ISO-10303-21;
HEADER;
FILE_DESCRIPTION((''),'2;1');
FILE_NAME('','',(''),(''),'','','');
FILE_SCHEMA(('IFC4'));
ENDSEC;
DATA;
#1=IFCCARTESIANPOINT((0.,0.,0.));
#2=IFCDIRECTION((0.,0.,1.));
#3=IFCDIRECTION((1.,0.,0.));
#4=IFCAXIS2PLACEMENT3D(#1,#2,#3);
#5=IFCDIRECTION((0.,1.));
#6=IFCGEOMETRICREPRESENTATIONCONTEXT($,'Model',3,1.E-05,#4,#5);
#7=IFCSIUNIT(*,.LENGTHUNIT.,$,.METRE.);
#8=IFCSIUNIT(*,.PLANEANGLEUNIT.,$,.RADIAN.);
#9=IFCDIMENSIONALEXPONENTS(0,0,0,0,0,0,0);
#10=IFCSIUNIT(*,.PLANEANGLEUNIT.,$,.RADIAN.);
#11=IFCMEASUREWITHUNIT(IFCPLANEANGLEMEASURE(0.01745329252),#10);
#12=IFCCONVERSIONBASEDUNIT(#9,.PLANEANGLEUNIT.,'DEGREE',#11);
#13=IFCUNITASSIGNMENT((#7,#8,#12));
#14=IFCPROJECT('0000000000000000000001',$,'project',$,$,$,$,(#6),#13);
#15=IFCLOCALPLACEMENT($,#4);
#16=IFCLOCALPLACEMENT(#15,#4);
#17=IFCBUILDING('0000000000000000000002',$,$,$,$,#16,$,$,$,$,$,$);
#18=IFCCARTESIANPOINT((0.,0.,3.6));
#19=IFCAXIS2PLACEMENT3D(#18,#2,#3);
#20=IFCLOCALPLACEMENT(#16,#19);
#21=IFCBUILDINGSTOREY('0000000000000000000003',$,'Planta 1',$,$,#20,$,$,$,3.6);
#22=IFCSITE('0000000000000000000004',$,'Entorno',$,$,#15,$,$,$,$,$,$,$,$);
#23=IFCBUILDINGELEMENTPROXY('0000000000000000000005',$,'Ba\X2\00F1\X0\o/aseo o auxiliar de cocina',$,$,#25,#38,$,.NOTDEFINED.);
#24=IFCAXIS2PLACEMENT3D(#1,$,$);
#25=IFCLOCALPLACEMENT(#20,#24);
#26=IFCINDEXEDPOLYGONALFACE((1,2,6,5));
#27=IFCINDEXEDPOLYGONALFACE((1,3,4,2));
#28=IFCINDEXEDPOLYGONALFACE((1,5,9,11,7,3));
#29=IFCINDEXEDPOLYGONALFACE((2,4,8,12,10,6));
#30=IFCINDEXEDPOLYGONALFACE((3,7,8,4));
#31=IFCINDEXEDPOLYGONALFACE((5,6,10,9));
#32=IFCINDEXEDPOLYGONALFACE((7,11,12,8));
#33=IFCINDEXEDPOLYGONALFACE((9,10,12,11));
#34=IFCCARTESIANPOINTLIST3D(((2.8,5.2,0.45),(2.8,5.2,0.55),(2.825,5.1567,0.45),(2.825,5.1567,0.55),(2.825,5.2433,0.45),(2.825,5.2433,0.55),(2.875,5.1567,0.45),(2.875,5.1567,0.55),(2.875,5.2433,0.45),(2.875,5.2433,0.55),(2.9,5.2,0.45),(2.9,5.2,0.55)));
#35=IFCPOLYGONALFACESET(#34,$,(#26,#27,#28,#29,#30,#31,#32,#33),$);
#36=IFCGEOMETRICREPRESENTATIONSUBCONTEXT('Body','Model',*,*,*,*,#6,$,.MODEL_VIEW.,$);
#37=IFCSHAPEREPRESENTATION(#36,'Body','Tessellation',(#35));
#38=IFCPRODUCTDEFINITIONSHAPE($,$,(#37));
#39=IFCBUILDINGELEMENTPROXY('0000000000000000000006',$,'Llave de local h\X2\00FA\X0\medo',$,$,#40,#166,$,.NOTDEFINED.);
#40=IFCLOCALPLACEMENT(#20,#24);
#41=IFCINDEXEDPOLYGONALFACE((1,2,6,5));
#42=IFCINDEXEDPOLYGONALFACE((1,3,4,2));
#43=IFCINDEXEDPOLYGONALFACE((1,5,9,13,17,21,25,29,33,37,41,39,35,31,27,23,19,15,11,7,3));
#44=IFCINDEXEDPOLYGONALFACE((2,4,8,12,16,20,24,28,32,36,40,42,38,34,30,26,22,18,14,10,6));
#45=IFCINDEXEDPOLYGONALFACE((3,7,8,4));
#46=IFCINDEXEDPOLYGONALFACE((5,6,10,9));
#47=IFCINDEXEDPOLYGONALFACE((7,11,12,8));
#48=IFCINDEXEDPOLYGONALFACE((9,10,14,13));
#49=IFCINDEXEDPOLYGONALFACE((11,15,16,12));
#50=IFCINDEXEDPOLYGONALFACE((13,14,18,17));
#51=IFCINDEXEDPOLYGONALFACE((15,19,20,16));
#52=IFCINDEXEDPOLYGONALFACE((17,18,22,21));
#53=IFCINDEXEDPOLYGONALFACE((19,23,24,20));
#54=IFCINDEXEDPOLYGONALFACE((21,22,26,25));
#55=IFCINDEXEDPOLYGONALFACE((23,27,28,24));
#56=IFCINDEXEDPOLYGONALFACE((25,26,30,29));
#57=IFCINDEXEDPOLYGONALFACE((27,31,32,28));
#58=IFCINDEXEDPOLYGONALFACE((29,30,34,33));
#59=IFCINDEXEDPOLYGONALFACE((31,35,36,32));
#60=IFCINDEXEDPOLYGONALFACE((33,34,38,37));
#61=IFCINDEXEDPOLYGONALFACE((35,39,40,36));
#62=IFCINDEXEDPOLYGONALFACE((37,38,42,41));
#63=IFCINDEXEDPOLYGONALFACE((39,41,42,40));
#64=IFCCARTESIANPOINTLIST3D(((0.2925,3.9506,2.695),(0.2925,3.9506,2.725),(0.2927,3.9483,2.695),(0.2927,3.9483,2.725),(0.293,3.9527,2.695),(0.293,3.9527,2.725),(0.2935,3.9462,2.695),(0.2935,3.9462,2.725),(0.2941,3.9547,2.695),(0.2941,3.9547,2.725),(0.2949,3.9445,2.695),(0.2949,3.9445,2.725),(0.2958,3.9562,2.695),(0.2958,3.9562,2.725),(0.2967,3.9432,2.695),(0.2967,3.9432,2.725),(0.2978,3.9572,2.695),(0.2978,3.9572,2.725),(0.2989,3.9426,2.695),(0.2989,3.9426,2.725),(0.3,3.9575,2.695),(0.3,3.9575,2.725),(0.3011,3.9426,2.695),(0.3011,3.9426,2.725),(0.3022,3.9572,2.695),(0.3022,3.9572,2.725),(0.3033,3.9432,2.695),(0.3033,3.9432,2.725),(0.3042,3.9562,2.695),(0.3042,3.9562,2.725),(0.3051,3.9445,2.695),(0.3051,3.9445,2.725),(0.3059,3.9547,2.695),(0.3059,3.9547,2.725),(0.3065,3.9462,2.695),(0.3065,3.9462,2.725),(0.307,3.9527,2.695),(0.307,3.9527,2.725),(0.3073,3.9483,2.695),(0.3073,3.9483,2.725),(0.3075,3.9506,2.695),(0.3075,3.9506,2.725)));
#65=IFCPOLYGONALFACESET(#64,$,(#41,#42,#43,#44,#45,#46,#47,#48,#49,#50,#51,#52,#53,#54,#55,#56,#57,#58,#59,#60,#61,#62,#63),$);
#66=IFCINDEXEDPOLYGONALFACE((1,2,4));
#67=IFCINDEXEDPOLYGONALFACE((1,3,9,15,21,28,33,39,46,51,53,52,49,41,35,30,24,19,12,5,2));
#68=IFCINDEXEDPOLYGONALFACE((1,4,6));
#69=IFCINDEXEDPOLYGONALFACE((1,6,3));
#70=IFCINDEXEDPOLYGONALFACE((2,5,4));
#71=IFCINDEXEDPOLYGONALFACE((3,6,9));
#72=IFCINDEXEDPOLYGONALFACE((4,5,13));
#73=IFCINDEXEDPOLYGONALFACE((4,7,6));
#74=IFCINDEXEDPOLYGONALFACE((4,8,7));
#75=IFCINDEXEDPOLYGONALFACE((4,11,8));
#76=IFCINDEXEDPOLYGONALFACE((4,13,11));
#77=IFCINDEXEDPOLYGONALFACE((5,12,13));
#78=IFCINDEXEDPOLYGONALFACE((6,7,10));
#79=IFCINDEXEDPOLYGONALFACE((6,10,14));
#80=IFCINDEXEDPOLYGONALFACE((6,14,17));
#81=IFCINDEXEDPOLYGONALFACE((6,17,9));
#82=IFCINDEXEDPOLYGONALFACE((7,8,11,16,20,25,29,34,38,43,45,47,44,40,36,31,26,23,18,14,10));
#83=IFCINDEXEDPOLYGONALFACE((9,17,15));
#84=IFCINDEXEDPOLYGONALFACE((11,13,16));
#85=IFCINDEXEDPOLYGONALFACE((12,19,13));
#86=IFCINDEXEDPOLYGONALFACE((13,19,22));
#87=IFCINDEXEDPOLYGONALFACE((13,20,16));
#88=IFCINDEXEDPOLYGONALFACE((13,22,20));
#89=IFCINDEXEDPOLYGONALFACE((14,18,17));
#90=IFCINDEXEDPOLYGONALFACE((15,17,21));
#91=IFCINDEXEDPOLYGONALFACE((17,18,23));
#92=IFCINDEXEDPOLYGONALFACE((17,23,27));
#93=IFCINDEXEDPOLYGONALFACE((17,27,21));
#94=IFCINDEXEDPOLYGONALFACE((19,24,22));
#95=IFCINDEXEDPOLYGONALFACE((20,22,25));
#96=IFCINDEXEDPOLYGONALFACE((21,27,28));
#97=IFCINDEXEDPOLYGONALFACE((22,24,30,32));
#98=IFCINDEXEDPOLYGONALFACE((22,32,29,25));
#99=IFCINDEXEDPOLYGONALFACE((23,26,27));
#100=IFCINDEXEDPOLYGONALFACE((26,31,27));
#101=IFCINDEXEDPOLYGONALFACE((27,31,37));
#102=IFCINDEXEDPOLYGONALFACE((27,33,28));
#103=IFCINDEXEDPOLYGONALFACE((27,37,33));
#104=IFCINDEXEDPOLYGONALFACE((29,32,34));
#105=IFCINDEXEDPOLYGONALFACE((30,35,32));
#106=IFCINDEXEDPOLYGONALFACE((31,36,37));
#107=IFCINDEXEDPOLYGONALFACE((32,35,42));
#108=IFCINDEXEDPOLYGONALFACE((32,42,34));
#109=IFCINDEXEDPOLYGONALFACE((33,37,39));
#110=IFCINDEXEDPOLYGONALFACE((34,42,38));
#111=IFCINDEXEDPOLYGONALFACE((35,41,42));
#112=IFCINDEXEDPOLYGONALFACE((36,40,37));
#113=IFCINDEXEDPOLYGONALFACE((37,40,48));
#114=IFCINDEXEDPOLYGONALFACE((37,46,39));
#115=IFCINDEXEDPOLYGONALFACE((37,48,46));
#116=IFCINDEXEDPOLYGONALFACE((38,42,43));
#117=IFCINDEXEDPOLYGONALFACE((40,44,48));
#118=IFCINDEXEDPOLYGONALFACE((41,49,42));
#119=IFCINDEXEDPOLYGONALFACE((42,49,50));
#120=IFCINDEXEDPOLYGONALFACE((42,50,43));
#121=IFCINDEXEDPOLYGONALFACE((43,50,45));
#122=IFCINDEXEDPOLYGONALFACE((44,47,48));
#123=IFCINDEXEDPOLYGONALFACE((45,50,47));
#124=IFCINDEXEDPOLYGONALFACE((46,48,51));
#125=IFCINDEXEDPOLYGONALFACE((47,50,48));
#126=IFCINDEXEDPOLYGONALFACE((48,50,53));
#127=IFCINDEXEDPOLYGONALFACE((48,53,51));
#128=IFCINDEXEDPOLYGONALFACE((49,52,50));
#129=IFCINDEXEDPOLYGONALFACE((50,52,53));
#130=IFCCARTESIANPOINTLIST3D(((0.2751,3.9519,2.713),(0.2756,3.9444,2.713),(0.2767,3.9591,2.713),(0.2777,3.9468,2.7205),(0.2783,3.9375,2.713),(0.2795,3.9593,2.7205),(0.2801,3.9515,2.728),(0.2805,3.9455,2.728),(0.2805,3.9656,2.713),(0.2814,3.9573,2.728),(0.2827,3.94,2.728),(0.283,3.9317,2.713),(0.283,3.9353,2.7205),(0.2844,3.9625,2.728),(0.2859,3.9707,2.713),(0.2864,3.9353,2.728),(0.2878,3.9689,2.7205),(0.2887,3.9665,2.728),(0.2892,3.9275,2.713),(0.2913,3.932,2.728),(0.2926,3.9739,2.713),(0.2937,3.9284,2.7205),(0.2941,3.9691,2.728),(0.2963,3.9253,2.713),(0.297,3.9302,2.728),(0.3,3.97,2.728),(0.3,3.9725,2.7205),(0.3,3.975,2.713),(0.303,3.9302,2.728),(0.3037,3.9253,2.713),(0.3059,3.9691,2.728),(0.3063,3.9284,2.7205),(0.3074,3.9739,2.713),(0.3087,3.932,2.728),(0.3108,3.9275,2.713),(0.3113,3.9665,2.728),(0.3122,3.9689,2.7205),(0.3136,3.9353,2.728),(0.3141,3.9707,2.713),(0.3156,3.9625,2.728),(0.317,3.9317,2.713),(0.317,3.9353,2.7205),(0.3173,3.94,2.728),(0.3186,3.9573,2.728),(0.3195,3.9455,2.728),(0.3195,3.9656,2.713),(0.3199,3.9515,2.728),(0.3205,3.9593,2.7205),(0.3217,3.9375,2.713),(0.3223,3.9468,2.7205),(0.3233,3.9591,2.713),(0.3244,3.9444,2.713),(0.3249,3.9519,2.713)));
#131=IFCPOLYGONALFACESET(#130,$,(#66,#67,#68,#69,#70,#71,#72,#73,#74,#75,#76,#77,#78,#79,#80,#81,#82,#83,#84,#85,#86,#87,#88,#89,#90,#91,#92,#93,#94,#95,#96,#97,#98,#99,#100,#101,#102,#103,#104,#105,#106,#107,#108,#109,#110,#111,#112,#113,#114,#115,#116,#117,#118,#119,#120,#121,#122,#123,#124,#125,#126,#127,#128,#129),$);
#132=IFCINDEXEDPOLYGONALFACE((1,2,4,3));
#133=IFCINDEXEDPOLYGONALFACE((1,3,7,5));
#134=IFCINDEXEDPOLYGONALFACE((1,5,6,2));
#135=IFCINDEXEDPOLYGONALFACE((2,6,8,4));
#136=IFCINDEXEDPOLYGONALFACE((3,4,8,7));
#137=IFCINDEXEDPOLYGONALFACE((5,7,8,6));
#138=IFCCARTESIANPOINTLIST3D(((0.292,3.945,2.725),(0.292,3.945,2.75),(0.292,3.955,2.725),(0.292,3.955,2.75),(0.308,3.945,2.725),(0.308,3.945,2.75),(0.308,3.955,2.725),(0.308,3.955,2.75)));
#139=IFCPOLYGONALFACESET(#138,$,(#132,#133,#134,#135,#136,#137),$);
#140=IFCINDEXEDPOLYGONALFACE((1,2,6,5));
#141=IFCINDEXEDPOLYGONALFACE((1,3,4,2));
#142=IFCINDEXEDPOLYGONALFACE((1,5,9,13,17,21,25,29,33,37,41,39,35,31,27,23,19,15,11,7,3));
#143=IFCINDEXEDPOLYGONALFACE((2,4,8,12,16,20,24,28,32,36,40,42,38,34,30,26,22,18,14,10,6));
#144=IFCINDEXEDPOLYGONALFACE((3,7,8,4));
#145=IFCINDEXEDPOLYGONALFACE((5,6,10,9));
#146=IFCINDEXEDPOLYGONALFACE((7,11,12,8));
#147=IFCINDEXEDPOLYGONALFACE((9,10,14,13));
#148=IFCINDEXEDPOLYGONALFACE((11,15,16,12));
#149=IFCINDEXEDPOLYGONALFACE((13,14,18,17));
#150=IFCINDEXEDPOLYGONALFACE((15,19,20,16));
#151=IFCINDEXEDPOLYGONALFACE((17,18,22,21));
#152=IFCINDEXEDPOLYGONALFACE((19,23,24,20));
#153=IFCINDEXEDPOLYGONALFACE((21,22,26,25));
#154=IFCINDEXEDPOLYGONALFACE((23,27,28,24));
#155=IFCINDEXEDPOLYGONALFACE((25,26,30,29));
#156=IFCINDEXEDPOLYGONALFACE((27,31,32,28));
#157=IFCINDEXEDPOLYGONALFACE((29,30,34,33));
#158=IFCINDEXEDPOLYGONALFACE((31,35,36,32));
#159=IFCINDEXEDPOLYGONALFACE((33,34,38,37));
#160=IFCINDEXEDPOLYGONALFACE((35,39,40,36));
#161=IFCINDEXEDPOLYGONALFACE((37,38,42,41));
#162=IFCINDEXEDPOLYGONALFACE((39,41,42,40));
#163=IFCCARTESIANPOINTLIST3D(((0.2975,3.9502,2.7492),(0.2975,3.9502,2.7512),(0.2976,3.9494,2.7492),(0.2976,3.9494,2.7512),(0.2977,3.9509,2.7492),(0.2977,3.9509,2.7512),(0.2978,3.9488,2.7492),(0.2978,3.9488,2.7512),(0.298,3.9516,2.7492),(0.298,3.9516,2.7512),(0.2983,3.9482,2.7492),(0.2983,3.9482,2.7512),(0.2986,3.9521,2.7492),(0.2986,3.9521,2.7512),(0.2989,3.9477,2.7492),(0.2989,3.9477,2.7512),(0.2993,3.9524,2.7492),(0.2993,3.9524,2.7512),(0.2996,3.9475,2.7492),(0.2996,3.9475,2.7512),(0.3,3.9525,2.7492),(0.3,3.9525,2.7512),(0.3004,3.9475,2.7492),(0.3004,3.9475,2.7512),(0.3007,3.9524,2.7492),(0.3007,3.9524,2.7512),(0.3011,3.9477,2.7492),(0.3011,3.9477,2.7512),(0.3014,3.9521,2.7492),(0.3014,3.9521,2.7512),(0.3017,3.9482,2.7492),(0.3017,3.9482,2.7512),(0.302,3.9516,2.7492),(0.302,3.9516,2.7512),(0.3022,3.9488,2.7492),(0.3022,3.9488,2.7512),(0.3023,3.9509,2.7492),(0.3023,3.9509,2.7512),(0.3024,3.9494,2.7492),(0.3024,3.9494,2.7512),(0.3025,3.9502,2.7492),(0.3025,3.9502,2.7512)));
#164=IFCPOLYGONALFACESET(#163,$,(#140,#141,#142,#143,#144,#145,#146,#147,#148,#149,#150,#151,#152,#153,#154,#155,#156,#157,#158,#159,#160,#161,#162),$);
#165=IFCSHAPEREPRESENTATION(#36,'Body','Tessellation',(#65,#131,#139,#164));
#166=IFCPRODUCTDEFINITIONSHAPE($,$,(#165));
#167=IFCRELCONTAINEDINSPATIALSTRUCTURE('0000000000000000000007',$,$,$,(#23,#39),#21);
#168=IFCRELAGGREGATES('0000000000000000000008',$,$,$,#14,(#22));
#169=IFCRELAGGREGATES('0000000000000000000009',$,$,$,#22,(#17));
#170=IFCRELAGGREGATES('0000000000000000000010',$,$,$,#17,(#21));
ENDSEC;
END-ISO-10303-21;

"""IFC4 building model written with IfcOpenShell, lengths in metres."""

from ifc_helpers import new_model, entity, si_unit, converted_unit, direction, frame, origin_with_axes, place, context, subcontext, project, spatial, polyline, outline, extrude, source, transform, mapped, element, save


model = new_model("IFC4")

# Units and contexts
model_context = context("Model", 3, precision=1e-05, world=origin_with_axes(), true_north=direction((0.0, 1.0)))
body_context = subcontext(model_context, "Body", "Model", "MODEL_VIEW")
ifc_project = project(units=[si_unit("LENGTHUNIT", "METRE"), si_unit("PLANEANGLEUNIT", "RADIAN"), converted_unit("PLANEANGLEUNIT", "DEGREE", entity("IfcPlaneAngleMeasure", 0.01745329252), si_unit("PLANEANGLEUNIT", "RADIAN"), dimensions=[0, 0, 0, 0, 0, 0, 0])], contexts=[model_context])

# Site, building, storey
site_placement = place(None, origin_with_axes())
site = spatial("IfcSite", under=ifc_project, at=site_placement, Name="Entorno")
building_placement = place(site_placement, origin_with_axes())
building = spatial("IfcBuilding", under=site, at=building_placement)
storey_placement = place(building_placement, frame((0.0, 0.0, 3.6), z_axis=(0.0, 0.0, 1.0), x_axis=(1.0, 0.0, 0.0)))
storey = spatial("IfcBuildingStorey", under=building, at=storey_placement, Name="Planta 1", Elevation=3.6)

# Building element proxies
shared_shape_1 = source(origin_with_axes(), body_context, "Body", "SolidModel", [
    extrude(outline(polyline([(0.05, 0.0), (0.025, 0.0433), (-0.025, 0.0433), (-0.05, 0.0), (-0.025, -0.0433), (0.025, -0.0433), (0.05, 0.0)])), frame((0.0, 0.0, -0.05), z_axis=(0.0, 0.0, 1.0), x_axis=(1.0, 0.0, 0.0)), (0.0, 0.0, 1.0), 0.1),
])
proxy_1_placement = place(storey_placement, frame((0.0, 0.0, -3.6), z_axis=(0.0, 0.0, 1.0), x_axis=(1.0, 0.0, 0.0)))
element("IfcBuildingElementProxy", 1, at=proxy_1_placement, inside=storey, Name="Baño/aseo o auxiliar de cocina", PredefinedType="NOTDEFINED", context=body_context, shape_type="Brep", body=[
    mapped(shared_shape_1, transform((2.85, 5.2, 4.1), x_axis=(-1.0, 0.0, 0.0), y_axis=(0.0, -1.0, 0.0), z_axis=(0.0, 0.0, 1.0))),
])
proxy_2_placement = place(storey_placement, frame((0.0, 0.0, -3.6), z_axis=(0.0, 0.0, 1.0), x_axis=(1.0, 0.0, 0.0)))
ifc_direction_1 = entity("IfcDirection", [0.0, 0.0, 1.0])
ifc_direction_2 = entity("IfcDirection", [0.0, 0.0, 1.0])
ifc_direction_3 = entity("IfcDirection", [0.0, 0.0, 1.0])
element("IfcBuildingElementProxy", 2, at=proxy_2_placement, inside=storey, Name="Llave de local húmedo", PredefinedType="NOTDEFINED", context=body_context, shape_type="Brep", body=[
    entity("IfcExtrudedAreaSolidTapered", entity("IfcCircleProfileDef", "AREA", None, entity("IfcAxis2Placement2D", entity("IfcCartesianPoint", [0.0, 0.0]), entity("IfcDirection", [1.0, 0.0])), 0.0075), entity("IfcAxis2Placement3D", entity("IfcCartesianPoint", [0.3, 3.95, 6.295]), ifc_direction_1, entity("IfcDirection", [0.0, 1.0, 0.0])), ifc_direction_1, 0.03, entity("IfcCircleProfileDef", "AREA", None, entity("IfcAxis2Placement2D", entity("IfcCartesianPoint", [0.0, 0.0]), entity("IfcDirection", [1.0, 0.0])), 0.0075)),
    entity("IfcExtrudedAreaSolidTapered", entity("IfcCircleProfileDef", "AREA", None, entity("IfcAxis2Placement2D", entity("IfcCartesianPoint", [0.0, 0.0]), entity("IfcDirection", [1.0, 0.0])), 0.025), entity("IfcAxis2Placement3D", entity("IfcCartesianPoint", [0.3, 3.95, 6.313]), ifc_direction_2, entity("IfcDirection", [0.0, 1.0, 0.0])), ifc_direction_2, 0.015, entity("IfcCircleProfileDef", "AREA", None, entity("IfcAxis2Placement2D", entity("IfcCartesianPoint", [0.0, 0.0]), entity("IfcDirection", [1.0, 0.0])), 0.02)),
    extrude(outline(polyline([(0.005, -0.008), (0.005, 0.008), (-0.005, 0.008), (-0.005, -0.008), (0.005, -0.008)])), frame((0.3, 3.95, 6.325), z_axis=(0.0, 0.0, 1.0), x_axis=(0.0, 1.0, 0.0)), (0.0, 0.0, 1.0), 0.025),
    entity("IfcExtrudedAreaSolidTapered", entity("IfcCircleProfileDef", "AREA", None, entity("IfcAxis2Placement2D", entity("IfcCartesianPoint", [0.0, 0.0]), entity("IfcDirection", [1.0, 0.0])), 0.0025), entity("IfcAxis2Placement3D", entity("IfcCartesianPoint", [0.3, 3.95, 6.3492]), ifc_direction_3, entity("IfcDirection", [0.0, 1.0, 0.0])), ifc_direction_3, 0.002, entity("IfcCircleProfileDef", "AREA", None, entity("IfcAxis2Placement2D", entity("IfcCartesianPoint", [0.0, 0.0]), entity("IfcDirection", [1.0, 0.0])), 0.0025)),
])

save(model, "model.ifc")
